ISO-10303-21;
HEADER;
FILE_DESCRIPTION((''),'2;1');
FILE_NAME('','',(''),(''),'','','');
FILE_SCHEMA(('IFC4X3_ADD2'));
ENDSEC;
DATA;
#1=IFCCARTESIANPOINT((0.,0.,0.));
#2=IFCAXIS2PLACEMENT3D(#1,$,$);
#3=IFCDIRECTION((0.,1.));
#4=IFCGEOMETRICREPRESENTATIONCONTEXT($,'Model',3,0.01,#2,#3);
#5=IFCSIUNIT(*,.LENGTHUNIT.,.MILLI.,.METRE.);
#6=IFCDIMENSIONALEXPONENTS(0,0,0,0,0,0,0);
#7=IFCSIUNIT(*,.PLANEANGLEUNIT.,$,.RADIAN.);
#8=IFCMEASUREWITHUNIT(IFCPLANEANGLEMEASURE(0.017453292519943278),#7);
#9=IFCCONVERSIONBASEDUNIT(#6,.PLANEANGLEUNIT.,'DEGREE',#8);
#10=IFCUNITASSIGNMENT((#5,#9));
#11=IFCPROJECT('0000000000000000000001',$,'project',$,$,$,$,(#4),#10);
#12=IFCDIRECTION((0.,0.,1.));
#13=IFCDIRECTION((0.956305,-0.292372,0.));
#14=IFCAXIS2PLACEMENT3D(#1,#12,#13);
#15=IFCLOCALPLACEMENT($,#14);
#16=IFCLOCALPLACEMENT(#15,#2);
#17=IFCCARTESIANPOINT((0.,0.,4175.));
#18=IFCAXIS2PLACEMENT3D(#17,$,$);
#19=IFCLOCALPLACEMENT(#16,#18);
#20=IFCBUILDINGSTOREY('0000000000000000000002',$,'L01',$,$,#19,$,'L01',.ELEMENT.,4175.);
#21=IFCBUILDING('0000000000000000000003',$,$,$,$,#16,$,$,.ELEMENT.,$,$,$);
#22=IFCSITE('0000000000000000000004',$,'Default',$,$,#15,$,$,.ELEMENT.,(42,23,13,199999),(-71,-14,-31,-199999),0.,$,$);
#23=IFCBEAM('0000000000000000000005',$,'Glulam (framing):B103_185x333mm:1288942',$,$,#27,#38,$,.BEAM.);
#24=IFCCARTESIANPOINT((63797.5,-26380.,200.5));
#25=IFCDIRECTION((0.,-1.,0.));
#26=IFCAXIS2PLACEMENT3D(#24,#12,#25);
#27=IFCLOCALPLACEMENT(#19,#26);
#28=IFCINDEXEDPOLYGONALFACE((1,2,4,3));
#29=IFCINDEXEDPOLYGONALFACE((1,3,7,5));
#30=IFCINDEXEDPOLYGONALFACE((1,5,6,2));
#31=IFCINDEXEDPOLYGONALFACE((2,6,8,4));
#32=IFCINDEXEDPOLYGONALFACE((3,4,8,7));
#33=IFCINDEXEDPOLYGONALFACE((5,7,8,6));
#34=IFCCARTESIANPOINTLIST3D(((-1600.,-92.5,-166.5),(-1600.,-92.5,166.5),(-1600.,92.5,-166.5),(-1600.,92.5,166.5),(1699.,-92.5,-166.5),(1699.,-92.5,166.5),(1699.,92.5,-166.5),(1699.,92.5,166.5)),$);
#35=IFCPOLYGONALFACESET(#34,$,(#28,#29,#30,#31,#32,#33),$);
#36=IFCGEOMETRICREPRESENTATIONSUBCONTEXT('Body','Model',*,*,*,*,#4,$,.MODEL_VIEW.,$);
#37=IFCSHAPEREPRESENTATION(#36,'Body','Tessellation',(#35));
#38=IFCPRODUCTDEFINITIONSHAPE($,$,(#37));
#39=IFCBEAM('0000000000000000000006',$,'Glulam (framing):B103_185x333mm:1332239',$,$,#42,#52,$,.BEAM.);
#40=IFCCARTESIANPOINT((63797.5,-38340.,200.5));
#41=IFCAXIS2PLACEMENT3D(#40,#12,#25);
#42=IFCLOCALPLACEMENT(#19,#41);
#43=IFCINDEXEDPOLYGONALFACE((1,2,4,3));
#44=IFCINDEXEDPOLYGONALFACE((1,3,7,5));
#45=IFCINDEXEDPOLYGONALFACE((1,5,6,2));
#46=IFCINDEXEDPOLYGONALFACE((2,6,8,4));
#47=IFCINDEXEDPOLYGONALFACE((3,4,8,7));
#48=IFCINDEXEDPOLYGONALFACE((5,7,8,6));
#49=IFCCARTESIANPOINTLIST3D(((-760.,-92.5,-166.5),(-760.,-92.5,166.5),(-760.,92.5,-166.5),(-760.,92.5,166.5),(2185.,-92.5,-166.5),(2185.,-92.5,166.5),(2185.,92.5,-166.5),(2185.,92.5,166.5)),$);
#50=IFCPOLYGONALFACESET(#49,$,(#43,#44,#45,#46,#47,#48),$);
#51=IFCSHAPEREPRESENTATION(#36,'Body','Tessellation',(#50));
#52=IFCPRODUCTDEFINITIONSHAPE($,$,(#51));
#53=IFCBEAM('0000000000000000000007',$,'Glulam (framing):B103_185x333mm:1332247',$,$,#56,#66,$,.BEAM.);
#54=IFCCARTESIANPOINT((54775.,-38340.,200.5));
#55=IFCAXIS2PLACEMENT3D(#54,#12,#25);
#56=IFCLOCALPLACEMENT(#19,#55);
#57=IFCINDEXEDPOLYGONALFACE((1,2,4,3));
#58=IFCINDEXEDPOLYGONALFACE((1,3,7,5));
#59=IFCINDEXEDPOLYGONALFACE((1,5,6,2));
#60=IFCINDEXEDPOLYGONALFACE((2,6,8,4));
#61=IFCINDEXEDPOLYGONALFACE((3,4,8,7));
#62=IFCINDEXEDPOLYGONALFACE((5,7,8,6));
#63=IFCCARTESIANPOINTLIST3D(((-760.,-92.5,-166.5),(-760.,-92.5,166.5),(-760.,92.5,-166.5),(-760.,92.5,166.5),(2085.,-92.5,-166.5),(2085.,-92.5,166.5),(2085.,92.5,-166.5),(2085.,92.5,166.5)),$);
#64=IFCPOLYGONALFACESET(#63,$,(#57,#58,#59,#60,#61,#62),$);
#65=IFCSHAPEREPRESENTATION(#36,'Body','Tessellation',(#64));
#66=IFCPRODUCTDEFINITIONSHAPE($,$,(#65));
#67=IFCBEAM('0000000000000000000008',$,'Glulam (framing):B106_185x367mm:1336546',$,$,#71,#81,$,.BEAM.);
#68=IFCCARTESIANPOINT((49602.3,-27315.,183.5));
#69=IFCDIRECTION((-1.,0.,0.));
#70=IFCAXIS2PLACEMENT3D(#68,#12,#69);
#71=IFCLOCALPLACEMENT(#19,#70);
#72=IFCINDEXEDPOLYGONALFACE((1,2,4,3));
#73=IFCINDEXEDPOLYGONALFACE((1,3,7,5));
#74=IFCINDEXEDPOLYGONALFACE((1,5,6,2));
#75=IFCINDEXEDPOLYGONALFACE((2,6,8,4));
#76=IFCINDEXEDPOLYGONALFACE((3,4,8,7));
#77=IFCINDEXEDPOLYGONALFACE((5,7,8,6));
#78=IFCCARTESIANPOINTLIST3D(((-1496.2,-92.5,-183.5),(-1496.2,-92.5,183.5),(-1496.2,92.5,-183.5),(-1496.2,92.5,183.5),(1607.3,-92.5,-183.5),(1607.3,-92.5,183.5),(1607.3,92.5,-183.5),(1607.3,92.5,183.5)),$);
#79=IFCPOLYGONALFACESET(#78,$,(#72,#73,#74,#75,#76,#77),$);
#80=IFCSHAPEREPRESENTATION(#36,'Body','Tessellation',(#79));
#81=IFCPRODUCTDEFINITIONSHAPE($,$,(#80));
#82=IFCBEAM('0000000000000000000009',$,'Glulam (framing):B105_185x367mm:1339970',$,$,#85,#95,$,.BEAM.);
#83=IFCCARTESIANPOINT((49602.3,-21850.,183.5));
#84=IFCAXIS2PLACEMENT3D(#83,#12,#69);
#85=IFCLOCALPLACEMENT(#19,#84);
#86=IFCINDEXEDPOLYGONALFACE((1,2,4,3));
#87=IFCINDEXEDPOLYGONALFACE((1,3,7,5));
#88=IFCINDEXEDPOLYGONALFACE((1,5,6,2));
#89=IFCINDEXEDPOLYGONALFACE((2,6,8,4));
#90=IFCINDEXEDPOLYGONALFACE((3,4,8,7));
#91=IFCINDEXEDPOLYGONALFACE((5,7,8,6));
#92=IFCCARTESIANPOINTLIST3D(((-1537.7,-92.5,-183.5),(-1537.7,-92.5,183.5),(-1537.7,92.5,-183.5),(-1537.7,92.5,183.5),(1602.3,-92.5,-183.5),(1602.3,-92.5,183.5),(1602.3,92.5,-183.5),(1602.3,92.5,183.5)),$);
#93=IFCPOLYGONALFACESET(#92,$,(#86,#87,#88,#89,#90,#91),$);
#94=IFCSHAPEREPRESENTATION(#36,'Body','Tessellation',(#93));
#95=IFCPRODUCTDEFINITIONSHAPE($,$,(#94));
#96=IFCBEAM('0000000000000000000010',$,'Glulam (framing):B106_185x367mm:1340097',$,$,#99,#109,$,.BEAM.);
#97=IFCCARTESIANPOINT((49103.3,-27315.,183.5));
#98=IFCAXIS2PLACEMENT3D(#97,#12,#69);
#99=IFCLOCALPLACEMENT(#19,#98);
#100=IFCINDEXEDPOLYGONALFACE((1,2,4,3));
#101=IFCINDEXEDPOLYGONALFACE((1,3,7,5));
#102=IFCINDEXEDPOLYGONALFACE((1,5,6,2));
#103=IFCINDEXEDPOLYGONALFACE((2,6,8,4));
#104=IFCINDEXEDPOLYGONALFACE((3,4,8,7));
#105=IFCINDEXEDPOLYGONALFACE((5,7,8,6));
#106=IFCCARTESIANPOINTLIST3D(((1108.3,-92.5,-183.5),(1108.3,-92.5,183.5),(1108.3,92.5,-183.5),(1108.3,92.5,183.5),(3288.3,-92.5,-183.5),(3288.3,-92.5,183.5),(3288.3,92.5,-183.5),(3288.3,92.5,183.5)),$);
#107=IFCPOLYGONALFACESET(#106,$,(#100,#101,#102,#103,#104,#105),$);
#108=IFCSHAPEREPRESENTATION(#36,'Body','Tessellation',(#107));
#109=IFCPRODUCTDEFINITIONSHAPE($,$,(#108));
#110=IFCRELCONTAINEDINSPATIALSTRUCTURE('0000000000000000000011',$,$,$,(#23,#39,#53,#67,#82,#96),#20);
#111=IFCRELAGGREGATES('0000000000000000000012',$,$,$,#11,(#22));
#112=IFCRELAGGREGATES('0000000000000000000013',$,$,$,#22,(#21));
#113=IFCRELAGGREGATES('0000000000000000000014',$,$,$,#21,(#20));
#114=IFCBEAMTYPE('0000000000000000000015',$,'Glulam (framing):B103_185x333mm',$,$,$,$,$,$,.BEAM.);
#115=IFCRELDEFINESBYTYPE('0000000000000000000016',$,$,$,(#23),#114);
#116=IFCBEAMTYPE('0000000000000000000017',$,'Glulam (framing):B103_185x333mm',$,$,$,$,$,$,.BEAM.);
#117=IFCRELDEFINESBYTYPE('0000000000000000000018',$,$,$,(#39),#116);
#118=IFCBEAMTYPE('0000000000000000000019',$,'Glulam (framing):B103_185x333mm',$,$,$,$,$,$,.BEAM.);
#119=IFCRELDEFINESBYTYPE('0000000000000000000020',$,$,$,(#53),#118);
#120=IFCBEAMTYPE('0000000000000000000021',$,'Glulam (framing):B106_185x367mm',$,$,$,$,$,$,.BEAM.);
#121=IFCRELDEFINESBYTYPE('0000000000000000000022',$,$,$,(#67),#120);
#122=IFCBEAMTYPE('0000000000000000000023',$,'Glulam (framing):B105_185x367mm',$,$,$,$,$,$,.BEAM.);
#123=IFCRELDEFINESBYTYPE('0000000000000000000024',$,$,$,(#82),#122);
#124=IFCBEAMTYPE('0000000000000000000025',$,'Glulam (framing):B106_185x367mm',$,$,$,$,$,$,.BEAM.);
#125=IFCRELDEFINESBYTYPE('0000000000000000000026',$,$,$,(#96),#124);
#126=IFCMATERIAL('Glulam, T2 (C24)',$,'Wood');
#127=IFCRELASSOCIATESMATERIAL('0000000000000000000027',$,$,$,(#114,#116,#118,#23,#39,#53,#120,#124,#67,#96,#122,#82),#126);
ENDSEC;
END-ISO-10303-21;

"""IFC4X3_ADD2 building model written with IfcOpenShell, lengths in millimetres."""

from ifc_helpers import new_model, entity, si_unit, converted_unit, direction, frame, frame_2d, origin, origin_2d_with_axis, place, context, subcontext, project, spatial, rectangle, extrude, source, transform, mapped, material, material_profile, profile_set, profile_usage, type_object, type_shapes, element, save


model = new_model("IFC4X3_ADD2")

# Units and contexts
model_context = context("Model", 3, precision=0.01, world=origin(), true_north=direction((0.0, 1.0)))
body_context = subcontext(model_context, "Body", "Model", "MODEL_VIEW")
ifc_project = project(units=[si_unit("LENGTHUNIT", "METRE", prefix="MILLI"), converted_unit("PLANEANGLEUNIT", "DEGREE", entity("IfcPlaneAngleMeasure", 0.017453292519943278), si_unit("PLANEANGLEUNIT", "RADIAN"), dimensions=[0, 0, 0, 0, 0, 0, 0])], contexts=[model_context])

# Site, building, storey
site_placement = place(None, frame((0.0, 0.0, 0.0), z_axis=(0.0, 0.0, 1.0), x_axis=(0.956305, -0.292372, 0.0)))
site = spatial("IfcSite", under=ifc_project, at=site_placement, Name="Default", CompositionType="ELEMENT", RefLatitude=(42, 23, 13, 199999), RefLongitude=(-71, -14, -31, -199999), RefElevation=0.0)
building_placement = place(site_placement, origin())
building = spatial("IfcBuilding", under=site, at=building_placement, CompositionType="ELEMENT")
storey_placement = place(building_placement, frame((0.0, 0.0, 4175.0)))
storey = spatial("IfcBuildingStorey", under=building, at=storey_placement, Name="L01", LongName="L01", CompositionType="ELEMENT", Elevation=4175.0)

# Beams
ifc_material_1 = material(Name="Glulam, T2 (C24)", Category="Wood")
ifc_material_profile_1 = material_profile(ifc_material_1, rectangle(XDim=3200.0, YDim=185.0, at=origin_2d_with_axis()), Name="B103_185x333mm")
ifc_profile_set_1 = profile_set([ifc_material_profile_1], Name="B103_185x333mm")
ifc_profile_usage_1 = profile_usage(ifc_profile_set_1, cardinal=8)
beam_type_1 = type_object("IfcBeamType", Name="Glulam (framing):B103_185x333mm", PredefinedType="BEAM", material=ifc_profile_set_1)
shared_shape_1 = source(origin(), body_context, "Body", "SweptSolid", [
    extrude(rectangle(XDim=185.0, YDim=3299.0, at=origin_2d_with_axis()), frame((49.5, 0.0, -166.5), z_axis=(0.0, 0.0, 1.0), x_axis=(0.0, 1.0, 0.0)), (0.0, 0.0, 1.0), 333.0),
])
type_shapes(beam_type_1, [shared_shape_1])
beam_1_placement = place(storey_placement, frame((63797.5, -26380.0, 200.5), z_axis=(0.0, 0.0, 1.0), x_axis=(0.0, -1.0, 0.0)))
element("IfcBeam", 1, at=beam_1_placement, inside=storey, type_object=beam_type_1, material=ifc_profile_usage_1, Name="Glulam (framing):B103_185x333mm:1288942", PredefinedType="BEAM", context=body_context, shape_type="MappedRepresentation", body=[
    mapped(shared_shape_1, transform((0.0, 0.0, 0.0), scale=1.0)),
])
beam_type_2 = type_object("IfcBeamType", Name="Glulam (framing):B103_185x333mm", PredefinedType="BEAM", material=ifc_profile_set_1)
shared_shape_2 = source(origin(), body_context, "Body", "SweptSolid", [
    extrude(rectangle(XDim=185.0, YDim=2945.0, at=origin_2d_with_axis()), frame((712.5, 0.0, -166.5), z_axis=(0.0, 0.0, 1.0), x_axis=(0.0, 1.0, 0.0)), (0.0, 0.0, 1.0), 333.0),
])
type_shapes(beam_type_2, [shared_shape_2])
beam_2_placement = place(storey_placement, frame((63797.5, -38340.0, 200.5), z_axis=(0.0, 0.0, 1.0), x_axis=(0.0, -1.0, 0.0)))
element("IfcBeam", 2, at=beam_2_placement, inside=storey, type_object=beam_type_2, material=ifc_profile_usage_1, Name="Glulam (framing):B103_185x333mm:1332239", PredefinedType="BEAM", context=body_context, shape_type="MappedRepresentation", body=[
    mapped(shared_shape_2, transform((0.0, 0.0, 0.0), scale=1.0)),
])
beam_type_3 = type_object("IfcBeamType", Name="Glulam (framing):B103_185x333mm", PredefinedType="BEAM", material=ifc_profile_set_1)
shared_shape_3 = source(origin(), body_context, "Body", "SweptSolid", [
    extrude(rectangle(XDim=185.0, YDim=2845.0, at=origin_2d_with_axis()), frame((662.5, 0.0, -166.5), z_axis=(0.0, 0.0, 1.0), x_axis=(0.0, 1.0, 0.0)), (0.0, 0.0, 1.0), 333.0),
])
type_shapes(beam_type_3, [shared_shape_3])
beam_3_placement = place(storey_placement, frame((54775.0, -38340.0, 200.5), z_axis=(0.0, 0.0, 1.0), x_axis=(0.0, -1.0, 0.0)))
element("IfcBeam", 3, at=beam_3_placement, inside=storey, type_object=beam_type_3, material=ifc_profile_usage_1, Name="Glulam (framing):B103_185x333mm:1332247", PredefinedType="BEAM", context=body_context, shape_type="MappedRepresentation", body=[
    mapped(shared_shape_3, transform((0.0, 0.0, 0.0), scale=1.0)),
])
ifc_material_profile_2 = material_profile(ifc_material_1, rectangle(XDim=2161.0, YDim=185.0, at=frame_2d((0.0, 0.0), x_axis=(1.0, 0.0))), Name="B106_185x367mm")
ifc_profile_set_2 = profile_set([ifc_material_profile_2], Name="B106_185x367mm")
ifc_profile_usage_2 = profile_usage(ifc_profile_set_2, cardinal=8)
beam_type_4 = type_object("IfcBeamType", Name="Glulam (framing):B106_185x367mm", PredefinedType="BEAM", material=ifc_profile_set_2)
shared_shape_4 = source(origin(), body_context, "Body", "SweptSolid", [
    extrude(rectangle(XDim=3103.5, YDim=185.0, at=origin_2d_with_axis()), frame((55.6, 0.0, -183.5), z_axis=(0.0, 0.0, 1.0), x_axis=(-1.0, 0.0, 0.0)), (0.0, 0.0, 1.0), 367.0),
])
type_shapes(beam_type_4, [shared_shape_4])
beam_4_placement = place(storey_placement, frame((49602.3, -27315.0, 183.5), z_axis=(0.0, 0.0, 1.0), x_axis=(-1.0, 0.0, 0.0)))
element("IfcBeam", 4, at=beam_4_placement, inside=storey, type_object=beam_type_4, material=ifc_profile_usage_2, Name="Glulam (framing):B106_185x367mm:1336546", PredefinedType="BEAM", context=body_context, shape_type="MappedRepresentation", body=[
    mapped(shared_shape_4, transform((0.0, 0.0, 0.0), scale=1.0)),
])
ifc_material_profile_3 = material_profile(ifc_material_1, rectangle(XDim=3241.9, YDim=185.0, at=origin_2d_with_axis()), Name="B105_185x367mm")
ifc_profile_set_3 = profile_set([ifc_material_profile_3], Name="B105_185x367mm")
ifc_profile_usage_3 = profile_usage(ifc_profile_set_3, cardinal=8)
beam_type_5 = type_object("IfcBeamType", Name="Glulam (framing):B105_185x367mm", PredefinedType="BEAM", material=ifc_profile_set_3)
shared_shape_5 = source(origin(), body_context, "Body", "SweptSolid", [
    extrude(rectangle(XDim=3140.0, YDim=185.0, at=origin_2d_with_axis()), frame((32.3, 0.0, -183.5), z_axis=(0.0, 0.0, 1.0), x_axis=(-1.0, 0.0, 0.0)), (0.0, 0.0, 1.0), 367.0),
])
type_shapes(beam_type_5, [shared_shape_5])
beam_5_placement = place(storey_placement, frame((49602.3, -21850.0, 183.5), z_axis=(0.0, 0.0, 1.0), x_axis=(-1.0, 0.0, 0.0)))
element("IfcBeam", 5, at=beam_5_placement, inside=storey, type_object=beam_type_5, material=ifc_profile_usage_3, Name="Glulam (framing):B105_185x367mm:1339970", PredefinedType="BEAM", context=body_context, shape_type="MappedRepresentation", body=[
    mapped(shared_shape_5, transform((0.0, 0.0, 0.0), scale=1.0)),
])
beam_type_6 = type_object("IfcBeamType", Name="Glulam (framing):B106_185x367mm", PredefinedType="BEAM", material=ifc_profile_set_2)
shared_shape_6 = source(origin(), body_context, "Body", "SweptSolid", [
    extrude(rectangle(XDim=2180.0, YDim=185.0, at=frame_2d((0.0, 0.0), x_axis=(1.0, 0.0))), frame((2198.3, 0.0, -183.5), z_axis=(0.0, 0.0, 1.0), x_axis=(-1.0, 0.0, 0.0)), (0.0, 0.0, 1.0), 367.0),
])
type_shapes(beam_type_6, [shared_shape_6])
beam_6_placement = place(storey_placement, frame((49103.3, -27315.0, 183.5), z_axis=(0.0, 0.0, 1.0), x_axis=(-1.0, 0.0, 0.0)))
element("IfcBeam", 6, at=beam_6_placement, inside=storey, type_object=beam_type_6, material=ifc_profile_usage_2, Name="Glulam (framing):B106_185x367mm:1340097", PredefinedType="BEAM", context=body_context, shape_type="MappedRepresentation", body=[
    mapped(shared_shape_6, transform((0.0, 0.0, 0.0), scale=1.0)),
])

save(model, "model.ifc")
